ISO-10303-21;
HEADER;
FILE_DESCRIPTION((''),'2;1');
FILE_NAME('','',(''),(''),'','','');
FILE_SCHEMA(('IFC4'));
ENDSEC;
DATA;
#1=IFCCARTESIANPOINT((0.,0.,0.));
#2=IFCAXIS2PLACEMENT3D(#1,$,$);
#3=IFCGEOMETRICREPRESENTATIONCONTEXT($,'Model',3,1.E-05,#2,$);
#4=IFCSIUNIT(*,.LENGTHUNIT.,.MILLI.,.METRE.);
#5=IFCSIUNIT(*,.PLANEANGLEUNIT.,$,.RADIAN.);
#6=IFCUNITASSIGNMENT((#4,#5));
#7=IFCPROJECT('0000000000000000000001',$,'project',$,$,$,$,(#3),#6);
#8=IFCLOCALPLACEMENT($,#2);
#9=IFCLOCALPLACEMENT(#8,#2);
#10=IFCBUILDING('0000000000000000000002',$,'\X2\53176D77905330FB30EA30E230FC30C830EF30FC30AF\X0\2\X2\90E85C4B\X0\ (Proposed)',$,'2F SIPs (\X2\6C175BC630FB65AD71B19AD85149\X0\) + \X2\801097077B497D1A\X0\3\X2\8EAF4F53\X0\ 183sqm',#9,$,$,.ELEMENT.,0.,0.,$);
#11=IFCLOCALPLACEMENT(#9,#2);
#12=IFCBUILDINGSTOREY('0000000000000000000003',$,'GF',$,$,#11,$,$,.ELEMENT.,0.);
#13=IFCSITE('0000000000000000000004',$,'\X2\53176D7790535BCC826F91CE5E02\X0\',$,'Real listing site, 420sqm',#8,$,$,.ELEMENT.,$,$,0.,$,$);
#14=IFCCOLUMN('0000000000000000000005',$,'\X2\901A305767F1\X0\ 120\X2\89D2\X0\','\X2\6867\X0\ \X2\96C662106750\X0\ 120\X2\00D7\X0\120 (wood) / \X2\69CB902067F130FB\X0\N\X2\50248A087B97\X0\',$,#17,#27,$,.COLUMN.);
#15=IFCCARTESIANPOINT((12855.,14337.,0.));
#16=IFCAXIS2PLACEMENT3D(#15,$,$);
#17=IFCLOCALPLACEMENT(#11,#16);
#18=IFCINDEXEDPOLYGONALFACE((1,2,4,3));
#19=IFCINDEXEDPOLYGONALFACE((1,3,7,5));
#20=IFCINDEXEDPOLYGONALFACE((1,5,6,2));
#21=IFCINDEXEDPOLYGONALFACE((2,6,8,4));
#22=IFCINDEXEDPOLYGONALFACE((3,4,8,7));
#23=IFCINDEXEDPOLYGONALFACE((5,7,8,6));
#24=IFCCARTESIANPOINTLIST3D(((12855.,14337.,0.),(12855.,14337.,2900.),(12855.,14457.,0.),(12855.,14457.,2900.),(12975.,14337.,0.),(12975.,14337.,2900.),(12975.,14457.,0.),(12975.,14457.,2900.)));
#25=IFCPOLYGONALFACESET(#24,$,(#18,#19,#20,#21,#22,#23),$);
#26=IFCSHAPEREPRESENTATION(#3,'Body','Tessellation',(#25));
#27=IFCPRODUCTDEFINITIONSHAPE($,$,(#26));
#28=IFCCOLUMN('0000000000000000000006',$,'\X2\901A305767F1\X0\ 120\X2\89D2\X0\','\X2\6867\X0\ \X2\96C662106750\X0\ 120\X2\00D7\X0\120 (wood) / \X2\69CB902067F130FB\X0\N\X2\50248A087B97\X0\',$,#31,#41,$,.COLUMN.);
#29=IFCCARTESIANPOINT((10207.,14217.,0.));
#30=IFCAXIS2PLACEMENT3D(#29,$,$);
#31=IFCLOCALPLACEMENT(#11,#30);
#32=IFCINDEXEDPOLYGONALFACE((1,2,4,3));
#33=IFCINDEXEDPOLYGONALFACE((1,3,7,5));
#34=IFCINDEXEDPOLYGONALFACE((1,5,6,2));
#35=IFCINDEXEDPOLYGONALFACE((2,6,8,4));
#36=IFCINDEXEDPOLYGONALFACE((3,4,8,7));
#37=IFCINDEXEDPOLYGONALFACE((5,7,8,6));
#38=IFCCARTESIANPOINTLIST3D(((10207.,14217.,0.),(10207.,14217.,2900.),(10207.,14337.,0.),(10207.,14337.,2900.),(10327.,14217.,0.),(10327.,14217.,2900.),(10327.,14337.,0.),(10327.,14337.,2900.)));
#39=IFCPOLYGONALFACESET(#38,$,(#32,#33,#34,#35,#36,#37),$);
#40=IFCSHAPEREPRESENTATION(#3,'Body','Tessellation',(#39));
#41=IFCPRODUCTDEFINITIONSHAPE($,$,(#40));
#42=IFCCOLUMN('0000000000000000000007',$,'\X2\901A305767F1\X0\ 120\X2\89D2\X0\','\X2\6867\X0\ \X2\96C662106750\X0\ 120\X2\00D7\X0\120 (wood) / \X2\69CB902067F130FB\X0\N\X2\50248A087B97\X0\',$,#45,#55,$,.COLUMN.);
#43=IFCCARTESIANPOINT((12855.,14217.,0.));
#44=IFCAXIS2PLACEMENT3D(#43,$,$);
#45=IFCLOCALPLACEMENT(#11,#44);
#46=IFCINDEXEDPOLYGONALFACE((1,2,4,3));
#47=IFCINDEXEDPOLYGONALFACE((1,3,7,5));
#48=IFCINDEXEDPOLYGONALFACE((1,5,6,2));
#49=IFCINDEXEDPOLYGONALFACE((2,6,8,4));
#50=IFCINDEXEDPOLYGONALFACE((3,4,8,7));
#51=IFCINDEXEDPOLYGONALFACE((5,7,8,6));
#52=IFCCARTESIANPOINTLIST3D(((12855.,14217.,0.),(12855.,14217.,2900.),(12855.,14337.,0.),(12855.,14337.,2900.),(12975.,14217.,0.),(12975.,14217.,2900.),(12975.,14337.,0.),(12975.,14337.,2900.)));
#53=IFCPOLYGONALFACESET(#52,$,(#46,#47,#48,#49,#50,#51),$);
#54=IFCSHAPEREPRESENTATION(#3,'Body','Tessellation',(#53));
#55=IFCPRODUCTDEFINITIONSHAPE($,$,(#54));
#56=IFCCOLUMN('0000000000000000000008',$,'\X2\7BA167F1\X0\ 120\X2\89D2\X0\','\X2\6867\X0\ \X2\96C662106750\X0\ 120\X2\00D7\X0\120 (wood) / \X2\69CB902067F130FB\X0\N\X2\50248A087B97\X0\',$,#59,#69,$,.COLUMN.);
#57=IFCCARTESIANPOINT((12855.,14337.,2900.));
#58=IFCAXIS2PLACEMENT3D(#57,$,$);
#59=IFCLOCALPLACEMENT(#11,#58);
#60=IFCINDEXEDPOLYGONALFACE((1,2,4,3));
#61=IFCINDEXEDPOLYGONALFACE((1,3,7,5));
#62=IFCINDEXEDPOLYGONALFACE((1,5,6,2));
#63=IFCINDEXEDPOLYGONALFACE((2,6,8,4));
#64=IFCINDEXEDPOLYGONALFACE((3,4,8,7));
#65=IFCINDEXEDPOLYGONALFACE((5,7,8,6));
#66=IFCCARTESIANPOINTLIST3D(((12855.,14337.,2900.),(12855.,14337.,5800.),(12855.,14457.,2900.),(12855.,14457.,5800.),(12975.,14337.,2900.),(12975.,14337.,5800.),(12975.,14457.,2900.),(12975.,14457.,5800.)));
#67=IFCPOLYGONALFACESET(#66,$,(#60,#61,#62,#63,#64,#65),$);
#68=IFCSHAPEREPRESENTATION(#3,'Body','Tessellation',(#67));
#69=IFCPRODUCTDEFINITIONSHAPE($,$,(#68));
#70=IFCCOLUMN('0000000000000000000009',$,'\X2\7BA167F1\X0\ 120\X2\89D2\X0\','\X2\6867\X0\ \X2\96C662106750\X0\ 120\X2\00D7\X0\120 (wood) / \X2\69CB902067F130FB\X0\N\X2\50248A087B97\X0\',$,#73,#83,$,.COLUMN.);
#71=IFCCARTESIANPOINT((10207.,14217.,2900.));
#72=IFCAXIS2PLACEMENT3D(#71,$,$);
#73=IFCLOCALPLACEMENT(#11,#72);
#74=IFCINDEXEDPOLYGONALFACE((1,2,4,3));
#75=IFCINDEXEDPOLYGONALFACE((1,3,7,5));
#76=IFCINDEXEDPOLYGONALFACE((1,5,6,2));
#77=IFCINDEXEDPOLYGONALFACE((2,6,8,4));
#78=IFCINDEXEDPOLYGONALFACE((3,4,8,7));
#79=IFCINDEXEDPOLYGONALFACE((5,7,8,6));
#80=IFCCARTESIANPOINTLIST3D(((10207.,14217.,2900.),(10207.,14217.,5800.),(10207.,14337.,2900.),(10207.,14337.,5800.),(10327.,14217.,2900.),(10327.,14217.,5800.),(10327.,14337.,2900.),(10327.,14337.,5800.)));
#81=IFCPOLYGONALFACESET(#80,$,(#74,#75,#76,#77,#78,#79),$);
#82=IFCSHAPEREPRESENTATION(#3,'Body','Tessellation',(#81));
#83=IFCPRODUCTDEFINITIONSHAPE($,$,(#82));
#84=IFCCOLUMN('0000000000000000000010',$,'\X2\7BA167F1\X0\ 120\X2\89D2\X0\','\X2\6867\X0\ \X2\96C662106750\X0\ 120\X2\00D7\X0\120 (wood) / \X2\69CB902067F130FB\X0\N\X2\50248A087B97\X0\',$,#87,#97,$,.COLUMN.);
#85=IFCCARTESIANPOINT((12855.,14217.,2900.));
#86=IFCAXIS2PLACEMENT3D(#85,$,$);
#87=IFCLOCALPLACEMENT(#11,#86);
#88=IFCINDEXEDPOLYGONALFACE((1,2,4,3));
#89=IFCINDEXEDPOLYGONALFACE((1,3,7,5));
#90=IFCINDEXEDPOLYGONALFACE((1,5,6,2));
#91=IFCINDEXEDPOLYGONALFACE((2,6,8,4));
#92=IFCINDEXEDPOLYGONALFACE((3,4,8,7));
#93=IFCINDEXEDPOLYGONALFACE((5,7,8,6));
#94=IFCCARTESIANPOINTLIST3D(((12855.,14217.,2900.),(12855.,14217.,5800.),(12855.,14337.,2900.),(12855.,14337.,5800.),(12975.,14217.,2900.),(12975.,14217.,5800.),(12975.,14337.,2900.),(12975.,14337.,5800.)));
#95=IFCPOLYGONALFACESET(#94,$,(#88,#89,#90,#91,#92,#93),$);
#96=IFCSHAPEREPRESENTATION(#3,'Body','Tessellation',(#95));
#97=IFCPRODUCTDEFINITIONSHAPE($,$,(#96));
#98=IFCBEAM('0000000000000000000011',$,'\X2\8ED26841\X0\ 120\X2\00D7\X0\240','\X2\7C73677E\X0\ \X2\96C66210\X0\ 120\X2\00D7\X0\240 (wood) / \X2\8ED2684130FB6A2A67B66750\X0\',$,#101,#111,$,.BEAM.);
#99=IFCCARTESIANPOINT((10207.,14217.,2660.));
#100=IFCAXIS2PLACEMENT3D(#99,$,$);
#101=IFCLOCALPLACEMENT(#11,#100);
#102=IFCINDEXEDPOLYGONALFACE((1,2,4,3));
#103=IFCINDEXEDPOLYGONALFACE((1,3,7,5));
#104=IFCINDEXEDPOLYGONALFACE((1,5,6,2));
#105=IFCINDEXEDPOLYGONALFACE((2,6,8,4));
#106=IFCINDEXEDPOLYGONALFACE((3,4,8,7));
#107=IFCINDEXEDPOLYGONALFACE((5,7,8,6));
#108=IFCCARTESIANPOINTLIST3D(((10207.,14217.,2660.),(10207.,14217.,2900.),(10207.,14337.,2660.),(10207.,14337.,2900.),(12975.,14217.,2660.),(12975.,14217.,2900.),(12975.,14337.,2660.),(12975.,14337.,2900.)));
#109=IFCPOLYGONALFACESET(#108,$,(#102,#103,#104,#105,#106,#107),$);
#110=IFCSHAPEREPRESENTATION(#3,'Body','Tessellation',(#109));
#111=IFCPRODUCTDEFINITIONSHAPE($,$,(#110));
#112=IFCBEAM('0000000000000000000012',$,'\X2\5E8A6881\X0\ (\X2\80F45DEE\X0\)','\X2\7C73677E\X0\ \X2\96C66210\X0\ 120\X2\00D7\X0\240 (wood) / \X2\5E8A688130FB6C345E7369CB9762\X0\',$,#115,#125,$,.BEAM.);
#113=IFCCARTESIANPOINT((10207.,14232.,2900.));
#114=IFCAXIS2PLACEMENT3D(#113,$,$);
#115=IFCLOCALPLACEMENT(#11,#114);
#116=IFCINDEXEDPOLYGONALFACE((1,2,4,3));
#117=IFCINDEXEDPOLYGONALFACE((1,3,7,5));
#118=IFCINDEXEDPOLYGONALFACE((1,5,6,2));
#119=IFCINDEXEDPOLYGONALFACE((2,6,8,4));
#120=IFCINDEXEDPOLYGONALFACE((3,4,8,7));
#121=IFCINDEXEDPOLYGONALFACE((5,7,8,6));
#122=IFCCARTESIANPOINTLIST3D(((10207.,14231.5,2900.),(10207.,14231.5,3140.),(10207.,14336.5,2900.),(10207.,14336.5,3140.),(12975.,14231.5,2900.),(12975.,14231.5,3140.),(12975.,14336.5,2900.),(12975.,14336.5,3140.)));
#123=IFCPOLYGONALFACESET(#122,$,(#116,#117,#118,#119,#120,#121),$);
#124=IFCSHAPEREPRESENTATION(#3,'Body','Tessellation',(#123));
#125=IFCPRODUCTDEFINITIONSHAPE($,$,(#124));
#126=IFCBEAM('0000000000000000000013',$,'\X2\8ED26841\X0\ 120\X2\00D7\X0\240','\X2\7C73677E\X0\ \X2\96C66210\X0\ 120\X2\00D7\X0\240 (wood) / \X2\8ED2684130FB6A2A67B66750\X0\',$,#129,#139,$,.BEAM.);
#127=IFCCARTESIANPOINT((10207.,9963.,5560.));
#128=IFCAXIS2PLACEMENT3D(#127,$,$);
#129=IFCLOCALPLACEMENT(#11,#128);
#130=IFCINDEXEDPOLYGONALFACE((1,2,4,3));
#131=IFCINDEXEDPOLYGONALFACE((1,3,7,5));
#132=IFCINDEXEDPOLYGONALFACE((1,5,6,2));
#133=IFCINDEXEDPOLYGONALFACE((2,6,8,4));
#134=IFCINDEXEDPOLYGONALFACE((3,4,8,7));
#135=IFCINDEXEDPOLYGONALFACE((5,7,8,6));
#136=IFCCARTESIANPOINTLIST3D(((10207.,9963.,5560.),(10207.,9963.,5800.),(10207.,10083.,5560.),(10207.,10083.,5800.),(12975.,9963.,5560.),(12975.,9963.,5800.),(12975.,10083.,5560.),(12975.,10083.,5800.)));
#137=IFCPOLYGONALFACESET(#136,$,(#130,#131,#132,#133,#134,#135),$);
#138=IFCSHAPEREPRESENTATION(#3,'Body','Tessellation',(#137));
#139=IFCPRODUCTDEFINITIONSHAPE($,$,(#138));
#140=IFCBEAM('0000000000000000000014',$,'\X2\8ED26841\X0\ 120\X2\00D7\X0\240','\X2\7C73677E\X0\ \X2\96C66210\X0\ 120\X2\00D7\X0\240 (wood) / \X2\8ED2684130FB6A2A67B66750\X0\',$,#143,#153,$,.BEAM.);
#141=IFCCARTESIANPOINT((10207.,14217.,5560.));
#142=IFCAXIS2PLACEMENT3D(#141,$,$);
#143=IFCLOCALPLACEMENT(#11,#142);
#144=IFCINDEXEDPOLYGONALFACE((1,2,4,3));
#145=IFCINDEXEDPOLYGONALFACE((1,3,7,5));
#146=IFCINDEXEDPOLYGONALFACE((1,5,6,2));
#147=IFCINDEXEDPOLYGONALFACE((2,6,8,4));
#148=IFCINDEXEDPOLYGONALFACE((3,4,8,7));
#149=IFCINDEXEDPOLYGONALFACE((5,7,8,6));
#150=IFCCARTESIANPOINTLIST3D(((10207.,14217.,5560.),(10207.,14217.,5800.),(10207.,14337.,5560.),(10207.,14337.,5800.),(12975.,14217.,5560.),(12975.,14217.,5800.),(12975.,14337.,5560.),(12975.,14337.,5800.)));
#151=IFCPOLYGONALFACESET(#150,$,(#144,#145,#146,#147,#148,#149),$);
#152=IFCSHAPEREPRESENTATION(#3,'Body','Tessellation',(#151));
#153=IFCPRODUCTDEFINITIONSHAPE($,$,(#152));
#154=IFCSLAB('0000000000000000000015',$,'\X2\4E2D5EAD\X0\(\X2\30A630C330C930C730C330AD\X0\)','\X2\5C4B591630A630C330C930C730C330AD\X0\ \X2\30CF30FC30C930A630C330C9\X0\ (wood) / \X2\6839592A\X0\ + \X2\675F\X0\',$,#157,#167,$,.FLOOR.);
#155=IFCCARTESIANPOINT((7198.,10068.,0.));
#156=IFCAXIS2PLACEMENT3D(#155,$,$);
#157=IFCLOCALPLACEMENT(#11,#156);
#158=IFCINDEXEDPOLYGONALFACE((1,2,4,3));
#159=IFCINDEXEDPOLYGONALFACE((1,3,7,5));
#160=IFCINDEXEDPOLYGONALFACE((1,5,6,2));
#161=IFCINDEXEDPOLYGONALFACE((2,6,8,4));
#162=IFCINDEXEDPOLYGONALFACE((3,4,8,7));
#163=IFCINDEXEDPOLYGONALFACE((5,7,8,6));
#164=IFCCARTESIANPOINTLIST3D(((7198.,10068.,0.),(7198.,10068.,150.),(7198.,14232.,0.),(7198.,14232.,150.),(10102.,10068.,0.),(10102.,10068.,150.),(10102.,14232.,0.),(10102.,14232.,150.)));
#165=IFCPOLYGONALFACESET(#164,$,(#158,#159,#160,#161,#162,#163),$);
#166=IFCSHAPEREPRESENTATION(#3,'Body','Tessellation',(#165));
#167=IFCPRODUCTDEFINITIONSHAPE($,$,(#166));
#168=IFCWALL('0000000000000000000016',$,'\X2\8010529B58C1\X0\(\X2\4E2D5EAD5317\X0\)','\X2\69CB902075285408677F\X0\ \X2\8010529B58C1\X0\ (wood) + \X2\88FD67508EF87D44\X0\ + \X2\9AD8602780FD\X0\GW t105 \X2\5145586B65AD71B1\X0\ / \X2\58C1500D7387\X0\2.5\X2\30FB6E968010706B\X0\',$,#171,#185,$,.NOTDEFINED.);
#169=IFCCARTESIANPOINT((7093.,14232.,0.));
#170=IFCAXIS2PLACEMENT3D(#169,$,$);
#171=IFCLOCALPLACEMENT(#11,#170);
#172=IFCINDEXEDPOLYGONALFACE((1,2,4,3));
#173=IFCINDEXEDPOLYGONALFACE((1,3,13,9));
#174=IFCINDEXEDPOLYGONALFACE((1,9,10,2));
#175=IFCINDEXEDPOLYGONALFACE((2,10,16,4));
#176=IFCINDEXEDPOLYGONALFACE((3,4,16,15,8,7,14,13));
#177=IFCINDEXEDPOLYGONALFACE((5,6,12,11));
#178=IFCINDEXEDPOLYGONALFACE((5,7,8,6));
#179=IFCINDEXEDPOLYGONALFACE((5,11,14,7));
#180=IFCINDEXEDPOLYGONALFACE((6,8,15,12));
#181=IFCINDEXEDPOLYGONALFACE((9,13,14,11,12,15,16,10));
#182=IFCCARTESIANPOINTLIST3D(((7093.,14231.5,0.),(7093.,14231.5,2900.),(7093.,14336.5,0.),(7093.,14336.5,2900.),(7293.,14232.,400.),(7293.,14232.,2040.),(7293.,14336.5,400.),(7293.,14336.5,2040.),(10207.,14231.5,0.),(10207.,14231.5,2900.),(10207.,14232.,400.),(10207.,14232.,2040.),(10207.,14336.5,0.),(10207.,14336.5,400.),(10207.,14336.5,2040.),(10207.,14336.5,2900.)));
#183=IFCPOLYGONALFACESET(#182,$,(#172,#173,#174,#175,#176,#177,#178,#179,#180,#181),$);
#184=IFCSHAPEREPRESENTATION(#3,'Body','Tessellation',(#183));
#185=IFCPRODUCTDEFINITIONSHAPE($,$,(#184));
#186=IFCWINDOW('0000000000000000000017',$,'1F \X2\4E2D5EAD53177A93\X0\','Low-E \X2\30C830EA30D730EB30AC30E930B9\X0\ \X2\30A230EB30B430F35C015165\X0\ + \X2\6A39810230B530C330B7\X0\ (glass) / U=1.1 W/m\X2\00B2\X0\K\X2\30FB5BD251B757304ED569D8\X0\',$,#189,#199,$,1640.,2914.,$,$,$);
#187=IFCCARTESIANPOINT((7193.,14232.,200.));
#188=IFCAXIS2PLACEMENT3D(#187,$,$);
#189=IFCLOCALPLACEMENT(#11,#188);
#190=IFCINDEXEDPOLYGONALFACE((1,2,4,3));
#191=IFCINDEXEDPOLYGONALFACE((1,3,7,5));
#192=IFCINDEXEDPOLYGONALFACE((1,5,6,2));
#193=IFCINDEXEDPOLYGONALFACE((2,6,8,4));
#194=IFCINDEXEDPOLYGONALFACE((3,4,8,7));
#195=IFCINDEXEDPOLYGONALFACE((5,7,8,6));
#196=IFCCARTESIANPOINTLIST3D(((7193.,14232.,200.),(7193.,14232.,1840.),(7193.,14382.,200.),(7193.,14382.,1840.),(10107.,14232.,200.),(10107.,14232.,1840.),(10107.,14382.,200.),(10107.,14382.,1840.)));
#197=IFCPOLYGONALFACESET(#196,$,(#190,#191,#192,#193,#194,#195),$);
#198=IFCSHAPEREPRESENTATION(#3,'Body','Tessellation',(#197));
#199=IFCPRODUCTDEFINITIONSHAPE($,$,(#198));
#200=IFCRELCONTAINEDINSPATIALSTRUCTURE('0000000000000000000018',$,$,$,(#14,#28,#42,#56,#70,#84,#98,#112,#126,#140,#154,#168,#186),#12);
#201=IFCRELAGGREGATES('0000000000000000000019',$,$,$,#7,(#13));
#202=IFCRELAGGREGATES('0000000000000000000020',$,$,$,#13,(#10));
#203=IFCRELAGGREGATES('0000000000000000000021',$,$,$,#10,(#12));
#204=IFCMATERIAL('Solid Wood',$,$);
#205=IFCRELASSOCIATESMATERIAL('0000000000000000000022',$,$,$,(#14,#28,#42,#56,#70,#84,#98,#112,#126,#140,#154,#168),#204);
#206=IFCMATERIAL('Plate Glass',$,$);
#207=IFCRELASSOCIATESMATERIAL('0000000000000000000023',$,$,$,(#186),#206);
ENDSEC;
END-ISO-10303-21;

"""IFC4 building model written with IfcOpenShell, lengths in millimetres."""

from ifc_helpers import new_model, si_unit, frame, frame_2d, origin, place, context, project, spatial, rectangle, extrude, material, element, fill, save


model = new_model("IFC4")

# Units and contexts
model_context = context("Model", 3, precision=1e-05, world=origin())
ifc_project = project(units=[si_unit("LENGTHUNIT", "METRE", prefix="MILLI"), si_unit("PLANEANGLEUNIT", "RADIAN")], contexts=[model_context])

# Site, building, storey
site_placement = place(None, origin())
site = spatial("IfcSite", under=ifc_project, at=site_placement, Name="北海道富良野市", ObjectType="Real listing site, 420sqm", CompositionType="ELEMENT", RefElevation=0.0)
building_placement = place(site_placement, origin())
building = spatial("IfcBuilding", under=site, at=building_placement, Name="北海道・リモートワーク2部屋 (Proposed)", ObjectType="2F SIPs (気密・断熱高光) + 耐震等級3躯体 183sqm", CompositionType="ELEMENT", ElevationOfRefHeight=0.0, ElevationOfTerrain=0.0)
storey_placement = place(building_placement, origin())
storey = spatial("IfcBuildingStorey", under=building, at=storey_placement, Name="GF", CompositionType="ELEMENT", Elevation=0.0)

# Columns
ifc_material_1 = material(Name="Solid Wood")
column_1_placement = place(storey_placement, frame((12855.0, 14337.0, 0.0)))
element("IfcColumn", 1, at=column_1_placement, inside=storey, material=ifc_material_1, Name="通し柱 120角", Description="桧 集成材 120×120 (wood) / 構造柱・N値計算", PredefinedType="COLUMN", context=model_context, shape_type="SweptSolid", body=[
    extrude(rectangle(XDim=120.0, YDim=120.0, at=frame_2d((60.0, 60.0))), frame((12855.0, 14337.0, 0.0)), (0.0, 0.0, 1.0), 2900.0),
])
column_2_placement = place(storey_placement, frame((10207.0, 14217.0, 0.0)))
element("IfcColumn", 2, at=column_2_placement, inside=storey, material=ifc_material_1, Name="通し柱 120角", Description="桧 集成材 120×120 (wood) / 構造柱・N値計算", PredefinedType="COLUMN", context=model_context, shape_type="SweptSolid", body=[
    extrude(rectangle(XDim=120.0, YDim=120.0, at=frame_2d((60.0, 60.0))), frame((10207.0, 14217.0, 0.0)), (0.0, 0.0, 1.0), 2900.0),
])
column_3_placement = place(storey_placement, frame((12855.0, 14217.0, 0.0)))
element("IfcColumn", 3, at=column_3_placement, inside=storey, material=ifc_material_1, Name="通し柱 120角", Description="桧 集成材 120×120 (wood) / 構造柱・N値計算", PredefinedType="COLUMN", context=model_context, shape_type="SweptSolid", body=[
    extrude(rectangle(XDim=120.0, YDim=120.0, at=frame_2d((60.0, 60.0))), frame((12855.0, 14217.0, 0.0)), (0.0, 0.0, 1.0), 2900.0),
])
column_4_placement = place(storey_placement, frame((12855.0, 14337.0, 2900.0)))
element("IfcColumn", 4, at=column_4_placement, inside=storey, material=ifc_material_1, Name="管柱 120角", Description="桧 集成材 120×120 (wood) / 構造柱・N値計算", PredefinedType="COLUMN", context=model_context, shape_type="SweptSolid", body=[
    extrude(rectangle(XDim=120.0, YDim=120.0, at=frame_2d((60.0, 60.0))), frame((12855.0, 14337.0, 2900.0)), (0.0, 0.0, 1.0), 2900.0),
])
column_5_placement = place(storey_placement, frame((10207.0, 14217.0, 2900.0)))
element("IfcColumn", 5, at=column_5_placement, inside=storey, material=ifc_material_1, Name="管柱 120角", Description="桧 集成材 120×120 (wood) / 構造柱・N値計算", PredefinedType="COLUMN", context=model_context, shape_type="SweptSolid", body=[
    extrude(rectangle(XDim=120.0, YDim=120.0, at=frame_2d((60.0, 60.0))), frame((10207.0, 14217.0, 2900.0)), (0.0, 0.0, 1.0), 2900.0),
])
column_6_placement = place(storey_placement, frame((12855.0, 14217.0, 2900.0)))
element("IfcColumn", 6, at=column_6_placement, inside=storey, material=ifc_material_1, Name="管柱 120角", Description="桧 集成材 120×120 (wood) / 構造柱・N値計算", PredefinedType="COLUMN", context=model_context, shape_type="SweptSolid", body=[
    extrude(rectangle(XDim=120.0, YDim=120.0, at=frame_2d((60.0, 60.0))), frame((12855.0, 14217.0, 2900.0)), (0.0, 0.0, 1.0), 2900.0),
])

# Beams
beam_1_placement = place(storey_placement, frame((10207.0, 14217.0, 2660.0)))
element("IfcBeam", 7, at=beam_1_placement, inside=storey, material=ifc_material_1, Name="軒桁 120×240", Description="米松 集成 120×240 (wood) / 軒桁・横架材", PredefinedType="BEAM", context=model_context, shape_type="SweptSolid", body=[
    extrude(rectangle(XDim=2768.0, YDim=120.0, at=frame_2d((1384.0, 60.0))), frame((10207.0, 14217.0, 2660.0)), (0.0, 0.0, 1.0), 240.0),
])
beam_2_placement = place(storey_placement, frame((10207.0, 14232.0, 2900.0)))
element("IfcBeam", 8, at=beam_2_placement, inside=storey, material=ifc_material_1, Name="床梁 (胴差)", Description="米松 集成 120×240 (wood) / 床梁・水平構面", PredefinedType="BEAM", context=model_context, shape_type="SweptSolid", body=[
    extrude(rectangle(XDim=2768.0, YDim=105.0, at=frame_2d((1384.0, 52.0))), frame((10207.0, 14232.0, 2900.0)), (0.0, 0.0, 1.0), 240.0),
])
beam_3_placement = place(storey_placement, frame((10207.0, 9963.0, 5560.0)))
element("IfcBeam", 9, at=beam_3_placement, inside=storey, material=ifc_material_1, Name="軒桁 120×240", Description="米松 集成 120×240 (wood) / 軒桁・横架材", PredefinedType="BEAM", context=model_context, shape_type="SweptSolid", body=[
    extrude(rectangle(XDim=2768.0, YDim=120.0, at=frame_2d((1384.0, 60.0))), frame((10207.0, 9963.0, 5560.0)), (0.0, 0.0, 1.0), 240.0),
])
beam_4_placement = place(storey_placement, frame((10207.0, 14217.0, 5560.0)))
element("IfcBeam", 10, at=beam_4_placement, inside=storey, material=ifc_material_1, Name="軒桁 120×240", Description="米松 集成 120×240 (wood) / 軒桁・横架材", PredefinedType="BEAM", context=model_context, shape_type="SweptSolid", body=[
    extrude(rectangle(XDim=2768.0, YDim=120.0, at=frame_2d((1384.0, 60.0))), frame((10207.0, 14217.0, 5560.0)), (0.0, 0.0, 1.0), 240.0),
])

# Slab
slab_placement = place(storey_placement, frame((7198.0, 10068.0, 0.0)))
element("IfcSlab", 11, at=slab_placement, inside=storey, material=ifc_material_1, Name="中庭(ウッドデッキ)", Description="屋外ウッドデッキ ハードウッド (wood) / 根太 + 束", PredefinedType="FLOOR", context=model_context, shape_type="SweptSolid", body=[
    extrude(rectangle(XDim=2904.0, YDim=4164.0, at=frame_2d((1452.0, 2082.0))), frame((7198.0, 10068.0, 0.0)), (0.0, 0.0, 1.0), 150.0),
])

# Wall, opening, window
wall_1_placement = place(storey_placement, frame((7093.0, 14232.0, 0.0)))
wall_1 = element("IfcWall", 12, at=wall_1_placement, inside=storey, material=ifc_material_1, Name="耐力壁(中庭北)", Description="構造用合板 耐力壁 (wood) + 製材軸組 + 高性能GW t105 充填断熱 / 壁倍率2.5・準耐火", PredefinedType="NOTDEFINED", context=model_context, shape_type="SweptSolid", body=[
    extrude(rectangle(XDim=3114.0, YDim=105.0, at=frame_2d((1557.0, 52.0))), frame((7093.0, 14232.0, 0.0)), (0.0, 0.0, 1.0), 2900.0),
])
opening_1_placement = place(storey_placement, frame((7193.0, 14232.0, 200.0)))
opening_1 = element("IfcOpeningElement", 13, at=opening_1_placement, cuts=wall_1, PredefinedType="NOTDEFINED", context=model_context, shape_type="SweptSolid", body=[
    extrude(rectangle(XDim=2914.0, YDim=150.0, at=frame_2d((1457.0, 75.0))), frame((7193.0, 14232.0, 200.0)), (0.0, 0.0, 1.0), 1640.0),
])
ifc_material_2 = material(Name="Plate Glass")
window_1_placement = place(storey_placement, frame((7193.0, 14232.0, 200.0)))
window_1 = element("IfcWindow", 14, at=window_1_placement, inside=storey, material=ifc_material_2, Name="1F 中庭北窓", Description="Low-E トリプルガラス アルゴン封入 + 樹脂サッシ (glass) / U=1.1 W/m²K・寒冷地仕様", OverallHeight=1640.0, OverallWidth=2914.0, context=model_context, shape_type="SweptSolid", body=[
    extrude(rectangle(XDim=2914.0, YDim=150.0, at=frame_2d((1457.0, 75.0))), frame((7193.0, 14232.0, 200.0)), (0.0, 0.0, 1.0), 1640.0),
])
fill(opening_1, window_1)

save(model, "model.ifc")
